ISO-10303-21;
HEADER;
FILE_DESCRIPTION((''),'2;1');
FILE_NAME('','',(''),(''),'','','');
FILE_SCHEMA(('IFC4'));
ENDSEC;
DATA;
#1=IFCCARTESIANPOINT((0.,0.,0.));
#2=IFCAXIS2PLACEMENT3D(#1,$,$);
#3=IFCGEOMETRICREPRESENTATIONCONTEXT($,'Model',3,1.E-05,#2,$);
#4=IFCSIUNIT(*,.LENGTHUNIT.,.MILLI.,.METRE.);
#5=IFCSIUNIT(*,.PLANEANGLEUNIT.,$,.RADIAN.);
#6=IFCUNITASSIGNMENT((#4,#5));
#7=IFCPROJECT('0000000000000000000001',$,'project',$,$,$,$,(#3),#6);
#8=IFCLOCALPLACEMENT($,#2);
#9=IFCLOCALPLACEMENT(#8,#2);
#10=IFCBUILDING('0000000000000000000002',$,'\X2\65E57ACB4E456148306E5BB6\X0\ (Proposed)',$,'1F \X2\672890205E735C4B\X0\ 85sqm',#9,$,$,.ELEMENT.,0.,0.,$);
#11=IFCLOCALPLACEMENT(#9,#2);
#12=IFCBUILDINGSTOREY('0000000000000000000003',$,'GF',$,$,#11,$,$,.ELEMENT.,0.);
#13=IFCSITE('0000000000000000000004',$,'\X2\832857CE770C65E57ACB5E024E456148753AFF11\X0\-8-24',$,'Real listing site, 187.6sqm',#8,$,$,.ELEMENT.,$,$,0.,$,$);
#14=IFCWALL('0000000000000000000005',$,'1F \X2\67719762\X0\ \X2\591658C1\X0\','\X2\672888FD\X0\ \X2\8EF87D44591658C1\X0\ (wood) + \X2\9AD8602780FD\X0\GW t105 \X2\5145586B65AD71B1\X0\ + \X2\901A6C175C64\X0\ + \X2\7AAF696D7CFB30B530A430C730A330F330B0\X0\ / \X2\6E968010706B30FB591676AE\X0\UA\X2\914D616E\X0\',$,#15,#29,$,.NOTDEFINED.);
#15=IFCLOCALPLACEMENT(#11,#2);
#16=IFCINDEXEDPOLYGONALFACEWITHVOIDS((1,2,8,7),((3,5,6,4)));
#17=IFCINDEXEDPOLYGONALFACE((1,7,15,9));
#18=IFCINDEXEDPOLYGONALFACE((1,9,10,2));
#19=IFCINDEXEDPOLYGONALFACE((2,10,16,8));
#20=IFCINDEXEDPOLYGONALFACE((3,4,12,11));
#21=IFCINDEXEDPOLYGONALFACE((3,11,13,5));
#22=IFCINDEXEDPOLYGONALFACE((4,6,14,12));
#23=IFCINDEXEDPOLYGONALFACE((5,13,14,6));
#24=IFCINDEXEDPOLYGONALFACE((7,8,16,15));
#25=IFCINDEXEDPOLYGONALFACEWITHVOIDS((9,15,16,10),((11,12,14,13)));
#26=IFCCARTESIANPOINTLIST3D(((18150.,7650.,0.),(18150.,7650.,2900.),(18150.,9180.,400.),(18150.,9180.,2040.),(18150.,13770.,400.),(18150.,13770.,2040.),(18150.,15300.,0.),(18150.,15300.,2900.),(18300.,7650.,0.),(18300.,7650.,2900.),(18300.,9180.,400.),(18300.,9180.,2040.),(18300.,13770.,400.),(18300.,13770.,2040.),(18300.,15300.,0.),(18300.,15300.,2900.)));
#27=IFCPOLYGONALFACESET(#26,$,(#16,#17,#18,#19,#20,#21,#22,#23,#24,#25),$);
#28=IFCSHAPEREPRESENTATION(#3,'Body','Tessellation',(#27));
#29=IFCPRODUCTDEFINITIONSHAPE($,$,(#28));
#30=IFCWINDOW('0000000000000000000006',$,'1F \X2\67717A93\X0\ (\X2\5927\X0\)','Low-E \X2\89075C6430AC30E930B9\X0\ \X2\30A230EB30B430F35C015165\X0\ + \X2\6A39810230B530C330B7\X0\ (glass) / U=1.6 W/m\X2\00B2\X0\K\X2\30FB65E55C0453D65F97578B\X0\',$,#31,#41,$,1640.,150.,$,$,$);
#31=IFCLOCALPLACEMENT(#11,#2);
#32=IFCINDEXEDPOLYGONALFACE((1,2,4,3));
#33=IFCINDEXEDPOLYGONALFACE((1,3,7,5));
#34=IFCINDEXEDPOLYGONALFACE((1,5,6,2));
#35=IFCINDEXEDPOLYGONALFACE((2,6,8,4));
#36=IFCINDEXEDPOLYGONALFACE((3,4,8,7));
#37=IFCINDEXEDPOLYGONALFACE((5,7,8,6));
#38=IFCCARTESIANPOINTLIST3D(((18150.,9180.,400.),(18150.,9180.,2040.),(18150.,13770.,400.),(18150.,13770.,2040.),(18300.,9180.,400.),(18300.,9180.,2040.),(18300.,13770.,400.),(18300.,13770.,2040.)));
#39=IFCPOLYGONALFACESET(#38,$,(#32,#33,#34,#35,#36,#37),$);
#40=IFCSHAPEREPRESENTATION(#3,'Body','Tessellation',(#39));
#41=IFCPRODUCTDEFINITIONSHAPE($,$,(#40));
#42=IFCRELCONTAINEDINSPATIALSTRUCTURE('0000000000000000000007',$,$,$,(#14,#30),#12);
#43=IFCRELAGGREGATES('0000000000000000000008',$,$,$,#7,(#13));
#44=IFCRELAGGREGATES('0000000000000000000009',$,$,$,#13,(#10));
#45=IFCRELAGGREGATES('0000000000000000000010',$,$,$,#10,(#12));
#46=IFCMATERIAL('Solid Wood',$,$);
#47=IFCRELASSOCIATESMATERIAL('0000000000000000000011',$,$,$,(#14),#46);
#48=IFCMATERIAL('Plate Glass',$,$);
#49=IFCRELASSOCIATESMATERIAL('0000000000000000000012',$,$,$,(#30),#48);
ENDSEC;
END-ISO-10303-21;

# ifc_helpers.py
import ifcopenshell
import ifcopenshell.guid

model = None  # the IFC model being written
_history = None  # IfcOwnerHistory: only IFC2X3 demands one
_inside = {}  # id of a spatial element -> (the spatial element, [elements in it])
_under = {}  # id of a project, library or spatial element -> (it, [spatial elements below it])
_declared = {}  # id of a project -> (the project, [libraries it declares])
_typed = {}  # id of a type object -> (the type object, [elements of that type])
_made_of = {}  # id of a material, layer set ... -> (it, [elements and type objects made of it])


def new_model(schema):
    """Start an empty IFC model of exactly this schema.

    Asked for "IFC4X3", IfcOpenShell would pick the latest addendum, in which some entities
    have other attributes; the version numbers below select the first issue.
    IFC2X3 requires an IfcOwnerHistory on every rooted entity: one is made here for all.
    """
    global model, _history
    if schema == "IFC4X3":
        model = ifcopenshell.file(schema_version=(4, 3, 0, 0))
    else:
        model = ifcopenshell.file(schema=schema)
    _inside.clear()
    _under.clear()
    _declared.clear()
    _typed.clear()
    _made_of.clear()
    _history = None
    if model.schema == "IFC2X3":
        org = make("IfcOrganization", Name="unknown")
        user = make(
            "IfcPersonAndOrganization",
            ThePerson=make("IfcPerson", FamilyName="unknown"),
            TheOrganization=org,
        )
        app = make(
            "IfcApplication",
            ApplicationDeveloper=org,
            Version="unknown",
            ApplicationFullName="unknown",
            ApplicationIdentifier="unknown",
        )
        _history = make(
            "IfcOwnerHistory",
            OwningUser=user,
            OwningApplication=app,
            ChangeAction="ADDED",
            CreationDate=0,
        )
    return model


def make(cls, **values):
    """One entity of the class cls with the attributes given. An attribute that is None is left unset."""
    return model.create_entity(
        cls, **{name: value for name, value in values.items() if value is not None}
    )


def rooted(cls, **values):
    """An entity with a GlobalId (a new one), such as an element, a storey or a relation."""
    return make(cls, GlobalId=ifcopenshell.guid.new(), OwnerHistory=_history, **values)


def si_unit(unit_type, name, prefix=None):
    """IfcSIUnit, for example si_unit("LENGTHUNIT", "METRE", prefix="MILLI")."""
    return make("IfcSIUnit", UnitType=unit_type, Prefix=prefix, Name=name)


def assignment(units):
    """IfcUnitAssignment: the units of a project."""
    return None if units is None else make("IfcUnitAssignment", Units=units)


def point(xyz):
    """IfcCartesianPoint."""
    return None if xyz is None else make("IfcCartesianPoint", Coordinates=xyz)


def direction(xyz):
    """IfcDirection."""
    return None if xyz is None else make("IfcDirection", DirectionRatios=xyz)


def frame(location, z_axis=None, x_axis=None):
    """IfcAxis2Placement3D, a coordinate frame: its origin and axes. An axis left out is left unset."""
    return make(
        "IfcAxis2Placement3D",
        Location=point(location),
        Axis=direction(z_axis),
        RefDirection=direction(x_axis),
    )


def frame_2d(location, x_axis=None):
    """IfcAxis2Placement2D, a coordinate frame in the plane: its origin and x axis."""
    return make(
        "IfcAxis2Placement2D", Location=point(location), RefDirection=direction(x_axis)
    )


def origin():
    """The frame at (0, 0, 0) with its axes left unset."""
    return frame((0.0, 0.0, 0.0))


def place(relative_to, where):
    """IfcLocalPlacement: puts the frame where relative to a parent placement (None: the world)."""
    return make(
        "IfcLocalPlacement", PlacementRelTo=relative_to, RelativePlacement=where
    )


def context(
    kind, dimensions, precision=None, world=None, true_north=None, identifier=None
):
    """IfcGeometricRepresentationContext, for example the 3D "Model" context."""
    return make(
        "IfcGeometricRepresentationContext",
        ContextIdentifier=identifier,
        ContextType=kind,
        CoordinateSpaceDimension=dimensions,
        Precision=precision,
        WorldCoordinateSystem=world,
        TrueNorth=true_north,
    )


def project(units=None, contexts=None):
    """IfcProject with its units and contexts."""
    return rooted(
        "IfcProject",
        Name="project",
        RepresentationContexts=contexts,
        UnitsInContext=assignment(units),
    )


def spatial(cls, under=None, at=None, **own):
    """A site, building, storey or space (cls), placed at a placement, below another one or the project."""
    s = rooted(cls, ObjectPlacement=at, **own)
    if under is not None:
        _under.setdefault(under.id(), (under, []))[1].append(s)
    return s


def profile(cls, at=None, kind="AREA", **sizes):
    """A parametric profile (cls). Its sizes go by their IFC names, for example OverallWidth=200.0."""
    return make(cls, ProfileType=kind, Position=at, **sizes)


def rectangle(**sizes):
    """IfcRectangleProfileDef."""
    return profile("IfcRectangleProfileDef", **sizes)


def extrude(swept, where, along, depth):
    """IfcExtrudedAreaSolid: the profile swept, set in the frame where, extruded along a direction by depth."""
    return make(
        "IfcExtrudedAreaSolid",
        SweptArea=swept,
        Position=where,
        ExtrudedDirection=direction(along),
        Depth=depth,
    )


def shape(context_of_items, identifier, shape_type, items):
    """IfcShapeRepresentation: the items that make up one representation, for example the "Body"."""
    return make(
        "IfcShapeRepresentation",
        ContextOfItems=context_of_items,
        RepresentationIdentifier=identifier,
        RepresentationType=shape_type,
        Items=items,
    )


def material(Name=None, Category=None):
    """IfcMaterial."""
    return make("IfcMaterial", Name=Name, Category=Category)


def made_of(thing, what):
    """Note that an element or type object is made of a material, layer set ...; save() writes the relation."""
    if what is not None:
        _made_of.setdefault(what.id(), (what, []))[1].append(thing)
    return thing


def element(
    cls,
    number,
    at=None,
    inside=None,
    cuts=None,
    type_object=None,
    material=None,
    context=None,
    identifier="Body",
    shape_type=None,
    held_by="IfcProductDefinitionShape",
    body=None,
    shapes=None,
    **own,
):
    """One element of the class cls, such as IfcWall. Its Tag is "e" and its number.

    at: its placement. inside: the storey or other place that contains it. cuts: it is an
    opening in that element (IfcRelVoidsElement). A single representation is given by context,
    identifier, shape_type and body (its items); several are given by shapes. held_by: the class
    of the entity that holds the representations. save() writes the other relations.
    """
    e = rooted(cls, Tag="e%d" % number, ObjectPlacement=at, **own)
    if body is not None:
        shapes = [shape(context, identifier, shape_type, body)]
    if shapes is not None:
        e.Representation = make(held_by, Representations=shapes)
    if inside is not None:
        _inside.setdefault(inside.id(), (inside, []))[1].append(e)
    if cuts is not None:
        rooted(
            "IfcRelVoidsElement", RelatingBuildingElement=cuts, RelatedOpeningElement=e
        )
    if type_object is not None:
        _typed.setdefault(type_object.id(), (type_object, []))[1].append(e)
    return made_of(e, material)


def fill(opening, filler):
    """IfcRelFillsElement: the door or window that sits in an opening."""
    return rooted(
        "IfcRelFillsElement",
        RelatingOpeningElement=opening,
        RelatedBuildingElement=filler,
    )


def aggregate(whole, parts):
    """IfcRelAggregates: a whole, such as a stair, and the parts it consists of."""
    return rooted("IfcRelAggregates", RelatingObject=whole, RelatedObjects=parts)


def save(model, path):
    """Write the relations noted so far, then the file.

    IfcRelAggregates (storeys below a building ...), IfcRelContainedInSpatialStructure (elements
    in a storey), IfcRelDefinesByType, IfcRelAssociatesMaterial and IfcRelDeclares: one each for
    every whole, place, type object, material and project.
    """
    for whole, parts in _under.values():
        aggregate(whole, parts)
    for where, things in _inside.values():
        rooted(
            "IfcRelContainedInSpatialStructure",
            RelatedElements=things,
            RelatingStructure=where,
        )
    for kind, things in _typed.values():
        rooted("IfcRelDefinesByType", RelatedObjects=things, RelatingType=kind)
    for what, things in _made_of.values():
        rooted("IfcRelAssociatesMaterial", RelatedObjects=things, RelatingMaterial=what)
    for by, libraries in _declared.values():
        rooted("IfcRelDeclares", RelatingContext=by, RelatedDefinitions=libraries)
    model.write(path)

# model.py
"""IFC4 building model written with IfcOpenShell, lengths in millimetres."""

from ifc_helpers import new_model, si_unit, frame, frame_2d, origin, place, context, project, spatial, rectangle, extrude, material, element, fill, save


model = new_model("IFC4")

# Units and contexts
model_context = context("Model", 3, precision=1e-05, world=origin())
ifc_project = project(units=[si_unit("LENGTHUNIT", "METRE", prefix="MILLI"), si_unit("PLANEANGLEUNIT", "RADIAN")], contexts=[model_context])

# Site, building, storey
site_placement = place(None, origin())
site = spatial("IfcSite", under=ifc_project, at=site_placement, Name="茨城県日立市久慈町１-8-24", ObjectType="Real listing site, 187.6sqm", CompositionType="ELEMENT", RefElevation=0.0)
building_placement = place(site_placement, origin())
building = spatial("IfcBuilding", under=site, at=building_placement, Name="日立久慈の家 (Proposed)", ObjectType="1F 木造平屋 85sqm", CompositionType="ELEMENT", ElevationOfRefHeight=0.0, ElevationOfTerrain=0.0)
storey_placement = place(building_placement, origin())
storey = spatial("IfcBuildingStorey", under=building, at=storey_placement, Name="GF", CompositionType="ELEMENT", Elevation=0.0)

# Wall, opening, window
ifc_material_1 = material(Name="Solid Wood")
wall_1_placement = place(storey_placement, frame((9075.0, 3825.0, 0.0)))
wall_1 = element("IfcWall", 1, at=wall_1_placement, inside=storey, material=ifc_material_1, Name="1F 東面 外壁", Description="木製 軸組外壁 (wood) + 高性能GW t105 充填断熱 + 通気層 + 窯業系サイディング / 準耐火・外皮UA配慮", PredefinedType="NOTDEFINED", context=model_context, shape_type="SweptSolid", body=[
    extrude(rectangle(XDim=150.0, YDim=7650.0, at=frame_2d((75.0, 3825.0))), frame((9075.0, 3825.0, 0.0)), (0.0, 0.0, 1.0), 2900.0),
])
opening_1_placement = place(storey_placement, frame((9075.0, 4590.0, 200.0)))
opening_1 = element("IfcOpeningElement", 2, at=opening_1_placement, cuts=wall_1, PredefinedType="NOTDEFINED", context=model_context, shape_type="SweptSolid", body=[
    extrude(rectangle(XDim=150.0, YDim=4590.0, at=frame_2d((75.0, 2295.0))), frame((9075.0, 4590.0, 200.0)), (0.0, 0.0, 1.0), 1640.0),
])
ifc_material_2 = material(Name="Plate Glass")
window_1_placement = place(storey_placement, frame((9075.0, 4590.0, 200.0)))
window_1 = element("IfcWindow", 3, at=window_1_placement, inside=storey, material=ifc_material_2, Name="1F 東窓 (大)", Description="Low-E 複層ガラス アルゴン封入 + 樹脂サッシ (glass) / U=1.6 W/m²K・日射取得型", OverallHeight=1640.0, OverallWidth=150.0, context=model_context, shape_type="SweptSolid", body=[
    extrude(rectangle(XDim=150.0, YDim=4590.0, at=frame_2d((75.0, 2295.0))), frame((9075.0, 4590.0, 200.0)), (0.0, 0.0, 1.0), 1640.0),
])
fill(opening_1, window_1)

save(model, "model.ifc")
